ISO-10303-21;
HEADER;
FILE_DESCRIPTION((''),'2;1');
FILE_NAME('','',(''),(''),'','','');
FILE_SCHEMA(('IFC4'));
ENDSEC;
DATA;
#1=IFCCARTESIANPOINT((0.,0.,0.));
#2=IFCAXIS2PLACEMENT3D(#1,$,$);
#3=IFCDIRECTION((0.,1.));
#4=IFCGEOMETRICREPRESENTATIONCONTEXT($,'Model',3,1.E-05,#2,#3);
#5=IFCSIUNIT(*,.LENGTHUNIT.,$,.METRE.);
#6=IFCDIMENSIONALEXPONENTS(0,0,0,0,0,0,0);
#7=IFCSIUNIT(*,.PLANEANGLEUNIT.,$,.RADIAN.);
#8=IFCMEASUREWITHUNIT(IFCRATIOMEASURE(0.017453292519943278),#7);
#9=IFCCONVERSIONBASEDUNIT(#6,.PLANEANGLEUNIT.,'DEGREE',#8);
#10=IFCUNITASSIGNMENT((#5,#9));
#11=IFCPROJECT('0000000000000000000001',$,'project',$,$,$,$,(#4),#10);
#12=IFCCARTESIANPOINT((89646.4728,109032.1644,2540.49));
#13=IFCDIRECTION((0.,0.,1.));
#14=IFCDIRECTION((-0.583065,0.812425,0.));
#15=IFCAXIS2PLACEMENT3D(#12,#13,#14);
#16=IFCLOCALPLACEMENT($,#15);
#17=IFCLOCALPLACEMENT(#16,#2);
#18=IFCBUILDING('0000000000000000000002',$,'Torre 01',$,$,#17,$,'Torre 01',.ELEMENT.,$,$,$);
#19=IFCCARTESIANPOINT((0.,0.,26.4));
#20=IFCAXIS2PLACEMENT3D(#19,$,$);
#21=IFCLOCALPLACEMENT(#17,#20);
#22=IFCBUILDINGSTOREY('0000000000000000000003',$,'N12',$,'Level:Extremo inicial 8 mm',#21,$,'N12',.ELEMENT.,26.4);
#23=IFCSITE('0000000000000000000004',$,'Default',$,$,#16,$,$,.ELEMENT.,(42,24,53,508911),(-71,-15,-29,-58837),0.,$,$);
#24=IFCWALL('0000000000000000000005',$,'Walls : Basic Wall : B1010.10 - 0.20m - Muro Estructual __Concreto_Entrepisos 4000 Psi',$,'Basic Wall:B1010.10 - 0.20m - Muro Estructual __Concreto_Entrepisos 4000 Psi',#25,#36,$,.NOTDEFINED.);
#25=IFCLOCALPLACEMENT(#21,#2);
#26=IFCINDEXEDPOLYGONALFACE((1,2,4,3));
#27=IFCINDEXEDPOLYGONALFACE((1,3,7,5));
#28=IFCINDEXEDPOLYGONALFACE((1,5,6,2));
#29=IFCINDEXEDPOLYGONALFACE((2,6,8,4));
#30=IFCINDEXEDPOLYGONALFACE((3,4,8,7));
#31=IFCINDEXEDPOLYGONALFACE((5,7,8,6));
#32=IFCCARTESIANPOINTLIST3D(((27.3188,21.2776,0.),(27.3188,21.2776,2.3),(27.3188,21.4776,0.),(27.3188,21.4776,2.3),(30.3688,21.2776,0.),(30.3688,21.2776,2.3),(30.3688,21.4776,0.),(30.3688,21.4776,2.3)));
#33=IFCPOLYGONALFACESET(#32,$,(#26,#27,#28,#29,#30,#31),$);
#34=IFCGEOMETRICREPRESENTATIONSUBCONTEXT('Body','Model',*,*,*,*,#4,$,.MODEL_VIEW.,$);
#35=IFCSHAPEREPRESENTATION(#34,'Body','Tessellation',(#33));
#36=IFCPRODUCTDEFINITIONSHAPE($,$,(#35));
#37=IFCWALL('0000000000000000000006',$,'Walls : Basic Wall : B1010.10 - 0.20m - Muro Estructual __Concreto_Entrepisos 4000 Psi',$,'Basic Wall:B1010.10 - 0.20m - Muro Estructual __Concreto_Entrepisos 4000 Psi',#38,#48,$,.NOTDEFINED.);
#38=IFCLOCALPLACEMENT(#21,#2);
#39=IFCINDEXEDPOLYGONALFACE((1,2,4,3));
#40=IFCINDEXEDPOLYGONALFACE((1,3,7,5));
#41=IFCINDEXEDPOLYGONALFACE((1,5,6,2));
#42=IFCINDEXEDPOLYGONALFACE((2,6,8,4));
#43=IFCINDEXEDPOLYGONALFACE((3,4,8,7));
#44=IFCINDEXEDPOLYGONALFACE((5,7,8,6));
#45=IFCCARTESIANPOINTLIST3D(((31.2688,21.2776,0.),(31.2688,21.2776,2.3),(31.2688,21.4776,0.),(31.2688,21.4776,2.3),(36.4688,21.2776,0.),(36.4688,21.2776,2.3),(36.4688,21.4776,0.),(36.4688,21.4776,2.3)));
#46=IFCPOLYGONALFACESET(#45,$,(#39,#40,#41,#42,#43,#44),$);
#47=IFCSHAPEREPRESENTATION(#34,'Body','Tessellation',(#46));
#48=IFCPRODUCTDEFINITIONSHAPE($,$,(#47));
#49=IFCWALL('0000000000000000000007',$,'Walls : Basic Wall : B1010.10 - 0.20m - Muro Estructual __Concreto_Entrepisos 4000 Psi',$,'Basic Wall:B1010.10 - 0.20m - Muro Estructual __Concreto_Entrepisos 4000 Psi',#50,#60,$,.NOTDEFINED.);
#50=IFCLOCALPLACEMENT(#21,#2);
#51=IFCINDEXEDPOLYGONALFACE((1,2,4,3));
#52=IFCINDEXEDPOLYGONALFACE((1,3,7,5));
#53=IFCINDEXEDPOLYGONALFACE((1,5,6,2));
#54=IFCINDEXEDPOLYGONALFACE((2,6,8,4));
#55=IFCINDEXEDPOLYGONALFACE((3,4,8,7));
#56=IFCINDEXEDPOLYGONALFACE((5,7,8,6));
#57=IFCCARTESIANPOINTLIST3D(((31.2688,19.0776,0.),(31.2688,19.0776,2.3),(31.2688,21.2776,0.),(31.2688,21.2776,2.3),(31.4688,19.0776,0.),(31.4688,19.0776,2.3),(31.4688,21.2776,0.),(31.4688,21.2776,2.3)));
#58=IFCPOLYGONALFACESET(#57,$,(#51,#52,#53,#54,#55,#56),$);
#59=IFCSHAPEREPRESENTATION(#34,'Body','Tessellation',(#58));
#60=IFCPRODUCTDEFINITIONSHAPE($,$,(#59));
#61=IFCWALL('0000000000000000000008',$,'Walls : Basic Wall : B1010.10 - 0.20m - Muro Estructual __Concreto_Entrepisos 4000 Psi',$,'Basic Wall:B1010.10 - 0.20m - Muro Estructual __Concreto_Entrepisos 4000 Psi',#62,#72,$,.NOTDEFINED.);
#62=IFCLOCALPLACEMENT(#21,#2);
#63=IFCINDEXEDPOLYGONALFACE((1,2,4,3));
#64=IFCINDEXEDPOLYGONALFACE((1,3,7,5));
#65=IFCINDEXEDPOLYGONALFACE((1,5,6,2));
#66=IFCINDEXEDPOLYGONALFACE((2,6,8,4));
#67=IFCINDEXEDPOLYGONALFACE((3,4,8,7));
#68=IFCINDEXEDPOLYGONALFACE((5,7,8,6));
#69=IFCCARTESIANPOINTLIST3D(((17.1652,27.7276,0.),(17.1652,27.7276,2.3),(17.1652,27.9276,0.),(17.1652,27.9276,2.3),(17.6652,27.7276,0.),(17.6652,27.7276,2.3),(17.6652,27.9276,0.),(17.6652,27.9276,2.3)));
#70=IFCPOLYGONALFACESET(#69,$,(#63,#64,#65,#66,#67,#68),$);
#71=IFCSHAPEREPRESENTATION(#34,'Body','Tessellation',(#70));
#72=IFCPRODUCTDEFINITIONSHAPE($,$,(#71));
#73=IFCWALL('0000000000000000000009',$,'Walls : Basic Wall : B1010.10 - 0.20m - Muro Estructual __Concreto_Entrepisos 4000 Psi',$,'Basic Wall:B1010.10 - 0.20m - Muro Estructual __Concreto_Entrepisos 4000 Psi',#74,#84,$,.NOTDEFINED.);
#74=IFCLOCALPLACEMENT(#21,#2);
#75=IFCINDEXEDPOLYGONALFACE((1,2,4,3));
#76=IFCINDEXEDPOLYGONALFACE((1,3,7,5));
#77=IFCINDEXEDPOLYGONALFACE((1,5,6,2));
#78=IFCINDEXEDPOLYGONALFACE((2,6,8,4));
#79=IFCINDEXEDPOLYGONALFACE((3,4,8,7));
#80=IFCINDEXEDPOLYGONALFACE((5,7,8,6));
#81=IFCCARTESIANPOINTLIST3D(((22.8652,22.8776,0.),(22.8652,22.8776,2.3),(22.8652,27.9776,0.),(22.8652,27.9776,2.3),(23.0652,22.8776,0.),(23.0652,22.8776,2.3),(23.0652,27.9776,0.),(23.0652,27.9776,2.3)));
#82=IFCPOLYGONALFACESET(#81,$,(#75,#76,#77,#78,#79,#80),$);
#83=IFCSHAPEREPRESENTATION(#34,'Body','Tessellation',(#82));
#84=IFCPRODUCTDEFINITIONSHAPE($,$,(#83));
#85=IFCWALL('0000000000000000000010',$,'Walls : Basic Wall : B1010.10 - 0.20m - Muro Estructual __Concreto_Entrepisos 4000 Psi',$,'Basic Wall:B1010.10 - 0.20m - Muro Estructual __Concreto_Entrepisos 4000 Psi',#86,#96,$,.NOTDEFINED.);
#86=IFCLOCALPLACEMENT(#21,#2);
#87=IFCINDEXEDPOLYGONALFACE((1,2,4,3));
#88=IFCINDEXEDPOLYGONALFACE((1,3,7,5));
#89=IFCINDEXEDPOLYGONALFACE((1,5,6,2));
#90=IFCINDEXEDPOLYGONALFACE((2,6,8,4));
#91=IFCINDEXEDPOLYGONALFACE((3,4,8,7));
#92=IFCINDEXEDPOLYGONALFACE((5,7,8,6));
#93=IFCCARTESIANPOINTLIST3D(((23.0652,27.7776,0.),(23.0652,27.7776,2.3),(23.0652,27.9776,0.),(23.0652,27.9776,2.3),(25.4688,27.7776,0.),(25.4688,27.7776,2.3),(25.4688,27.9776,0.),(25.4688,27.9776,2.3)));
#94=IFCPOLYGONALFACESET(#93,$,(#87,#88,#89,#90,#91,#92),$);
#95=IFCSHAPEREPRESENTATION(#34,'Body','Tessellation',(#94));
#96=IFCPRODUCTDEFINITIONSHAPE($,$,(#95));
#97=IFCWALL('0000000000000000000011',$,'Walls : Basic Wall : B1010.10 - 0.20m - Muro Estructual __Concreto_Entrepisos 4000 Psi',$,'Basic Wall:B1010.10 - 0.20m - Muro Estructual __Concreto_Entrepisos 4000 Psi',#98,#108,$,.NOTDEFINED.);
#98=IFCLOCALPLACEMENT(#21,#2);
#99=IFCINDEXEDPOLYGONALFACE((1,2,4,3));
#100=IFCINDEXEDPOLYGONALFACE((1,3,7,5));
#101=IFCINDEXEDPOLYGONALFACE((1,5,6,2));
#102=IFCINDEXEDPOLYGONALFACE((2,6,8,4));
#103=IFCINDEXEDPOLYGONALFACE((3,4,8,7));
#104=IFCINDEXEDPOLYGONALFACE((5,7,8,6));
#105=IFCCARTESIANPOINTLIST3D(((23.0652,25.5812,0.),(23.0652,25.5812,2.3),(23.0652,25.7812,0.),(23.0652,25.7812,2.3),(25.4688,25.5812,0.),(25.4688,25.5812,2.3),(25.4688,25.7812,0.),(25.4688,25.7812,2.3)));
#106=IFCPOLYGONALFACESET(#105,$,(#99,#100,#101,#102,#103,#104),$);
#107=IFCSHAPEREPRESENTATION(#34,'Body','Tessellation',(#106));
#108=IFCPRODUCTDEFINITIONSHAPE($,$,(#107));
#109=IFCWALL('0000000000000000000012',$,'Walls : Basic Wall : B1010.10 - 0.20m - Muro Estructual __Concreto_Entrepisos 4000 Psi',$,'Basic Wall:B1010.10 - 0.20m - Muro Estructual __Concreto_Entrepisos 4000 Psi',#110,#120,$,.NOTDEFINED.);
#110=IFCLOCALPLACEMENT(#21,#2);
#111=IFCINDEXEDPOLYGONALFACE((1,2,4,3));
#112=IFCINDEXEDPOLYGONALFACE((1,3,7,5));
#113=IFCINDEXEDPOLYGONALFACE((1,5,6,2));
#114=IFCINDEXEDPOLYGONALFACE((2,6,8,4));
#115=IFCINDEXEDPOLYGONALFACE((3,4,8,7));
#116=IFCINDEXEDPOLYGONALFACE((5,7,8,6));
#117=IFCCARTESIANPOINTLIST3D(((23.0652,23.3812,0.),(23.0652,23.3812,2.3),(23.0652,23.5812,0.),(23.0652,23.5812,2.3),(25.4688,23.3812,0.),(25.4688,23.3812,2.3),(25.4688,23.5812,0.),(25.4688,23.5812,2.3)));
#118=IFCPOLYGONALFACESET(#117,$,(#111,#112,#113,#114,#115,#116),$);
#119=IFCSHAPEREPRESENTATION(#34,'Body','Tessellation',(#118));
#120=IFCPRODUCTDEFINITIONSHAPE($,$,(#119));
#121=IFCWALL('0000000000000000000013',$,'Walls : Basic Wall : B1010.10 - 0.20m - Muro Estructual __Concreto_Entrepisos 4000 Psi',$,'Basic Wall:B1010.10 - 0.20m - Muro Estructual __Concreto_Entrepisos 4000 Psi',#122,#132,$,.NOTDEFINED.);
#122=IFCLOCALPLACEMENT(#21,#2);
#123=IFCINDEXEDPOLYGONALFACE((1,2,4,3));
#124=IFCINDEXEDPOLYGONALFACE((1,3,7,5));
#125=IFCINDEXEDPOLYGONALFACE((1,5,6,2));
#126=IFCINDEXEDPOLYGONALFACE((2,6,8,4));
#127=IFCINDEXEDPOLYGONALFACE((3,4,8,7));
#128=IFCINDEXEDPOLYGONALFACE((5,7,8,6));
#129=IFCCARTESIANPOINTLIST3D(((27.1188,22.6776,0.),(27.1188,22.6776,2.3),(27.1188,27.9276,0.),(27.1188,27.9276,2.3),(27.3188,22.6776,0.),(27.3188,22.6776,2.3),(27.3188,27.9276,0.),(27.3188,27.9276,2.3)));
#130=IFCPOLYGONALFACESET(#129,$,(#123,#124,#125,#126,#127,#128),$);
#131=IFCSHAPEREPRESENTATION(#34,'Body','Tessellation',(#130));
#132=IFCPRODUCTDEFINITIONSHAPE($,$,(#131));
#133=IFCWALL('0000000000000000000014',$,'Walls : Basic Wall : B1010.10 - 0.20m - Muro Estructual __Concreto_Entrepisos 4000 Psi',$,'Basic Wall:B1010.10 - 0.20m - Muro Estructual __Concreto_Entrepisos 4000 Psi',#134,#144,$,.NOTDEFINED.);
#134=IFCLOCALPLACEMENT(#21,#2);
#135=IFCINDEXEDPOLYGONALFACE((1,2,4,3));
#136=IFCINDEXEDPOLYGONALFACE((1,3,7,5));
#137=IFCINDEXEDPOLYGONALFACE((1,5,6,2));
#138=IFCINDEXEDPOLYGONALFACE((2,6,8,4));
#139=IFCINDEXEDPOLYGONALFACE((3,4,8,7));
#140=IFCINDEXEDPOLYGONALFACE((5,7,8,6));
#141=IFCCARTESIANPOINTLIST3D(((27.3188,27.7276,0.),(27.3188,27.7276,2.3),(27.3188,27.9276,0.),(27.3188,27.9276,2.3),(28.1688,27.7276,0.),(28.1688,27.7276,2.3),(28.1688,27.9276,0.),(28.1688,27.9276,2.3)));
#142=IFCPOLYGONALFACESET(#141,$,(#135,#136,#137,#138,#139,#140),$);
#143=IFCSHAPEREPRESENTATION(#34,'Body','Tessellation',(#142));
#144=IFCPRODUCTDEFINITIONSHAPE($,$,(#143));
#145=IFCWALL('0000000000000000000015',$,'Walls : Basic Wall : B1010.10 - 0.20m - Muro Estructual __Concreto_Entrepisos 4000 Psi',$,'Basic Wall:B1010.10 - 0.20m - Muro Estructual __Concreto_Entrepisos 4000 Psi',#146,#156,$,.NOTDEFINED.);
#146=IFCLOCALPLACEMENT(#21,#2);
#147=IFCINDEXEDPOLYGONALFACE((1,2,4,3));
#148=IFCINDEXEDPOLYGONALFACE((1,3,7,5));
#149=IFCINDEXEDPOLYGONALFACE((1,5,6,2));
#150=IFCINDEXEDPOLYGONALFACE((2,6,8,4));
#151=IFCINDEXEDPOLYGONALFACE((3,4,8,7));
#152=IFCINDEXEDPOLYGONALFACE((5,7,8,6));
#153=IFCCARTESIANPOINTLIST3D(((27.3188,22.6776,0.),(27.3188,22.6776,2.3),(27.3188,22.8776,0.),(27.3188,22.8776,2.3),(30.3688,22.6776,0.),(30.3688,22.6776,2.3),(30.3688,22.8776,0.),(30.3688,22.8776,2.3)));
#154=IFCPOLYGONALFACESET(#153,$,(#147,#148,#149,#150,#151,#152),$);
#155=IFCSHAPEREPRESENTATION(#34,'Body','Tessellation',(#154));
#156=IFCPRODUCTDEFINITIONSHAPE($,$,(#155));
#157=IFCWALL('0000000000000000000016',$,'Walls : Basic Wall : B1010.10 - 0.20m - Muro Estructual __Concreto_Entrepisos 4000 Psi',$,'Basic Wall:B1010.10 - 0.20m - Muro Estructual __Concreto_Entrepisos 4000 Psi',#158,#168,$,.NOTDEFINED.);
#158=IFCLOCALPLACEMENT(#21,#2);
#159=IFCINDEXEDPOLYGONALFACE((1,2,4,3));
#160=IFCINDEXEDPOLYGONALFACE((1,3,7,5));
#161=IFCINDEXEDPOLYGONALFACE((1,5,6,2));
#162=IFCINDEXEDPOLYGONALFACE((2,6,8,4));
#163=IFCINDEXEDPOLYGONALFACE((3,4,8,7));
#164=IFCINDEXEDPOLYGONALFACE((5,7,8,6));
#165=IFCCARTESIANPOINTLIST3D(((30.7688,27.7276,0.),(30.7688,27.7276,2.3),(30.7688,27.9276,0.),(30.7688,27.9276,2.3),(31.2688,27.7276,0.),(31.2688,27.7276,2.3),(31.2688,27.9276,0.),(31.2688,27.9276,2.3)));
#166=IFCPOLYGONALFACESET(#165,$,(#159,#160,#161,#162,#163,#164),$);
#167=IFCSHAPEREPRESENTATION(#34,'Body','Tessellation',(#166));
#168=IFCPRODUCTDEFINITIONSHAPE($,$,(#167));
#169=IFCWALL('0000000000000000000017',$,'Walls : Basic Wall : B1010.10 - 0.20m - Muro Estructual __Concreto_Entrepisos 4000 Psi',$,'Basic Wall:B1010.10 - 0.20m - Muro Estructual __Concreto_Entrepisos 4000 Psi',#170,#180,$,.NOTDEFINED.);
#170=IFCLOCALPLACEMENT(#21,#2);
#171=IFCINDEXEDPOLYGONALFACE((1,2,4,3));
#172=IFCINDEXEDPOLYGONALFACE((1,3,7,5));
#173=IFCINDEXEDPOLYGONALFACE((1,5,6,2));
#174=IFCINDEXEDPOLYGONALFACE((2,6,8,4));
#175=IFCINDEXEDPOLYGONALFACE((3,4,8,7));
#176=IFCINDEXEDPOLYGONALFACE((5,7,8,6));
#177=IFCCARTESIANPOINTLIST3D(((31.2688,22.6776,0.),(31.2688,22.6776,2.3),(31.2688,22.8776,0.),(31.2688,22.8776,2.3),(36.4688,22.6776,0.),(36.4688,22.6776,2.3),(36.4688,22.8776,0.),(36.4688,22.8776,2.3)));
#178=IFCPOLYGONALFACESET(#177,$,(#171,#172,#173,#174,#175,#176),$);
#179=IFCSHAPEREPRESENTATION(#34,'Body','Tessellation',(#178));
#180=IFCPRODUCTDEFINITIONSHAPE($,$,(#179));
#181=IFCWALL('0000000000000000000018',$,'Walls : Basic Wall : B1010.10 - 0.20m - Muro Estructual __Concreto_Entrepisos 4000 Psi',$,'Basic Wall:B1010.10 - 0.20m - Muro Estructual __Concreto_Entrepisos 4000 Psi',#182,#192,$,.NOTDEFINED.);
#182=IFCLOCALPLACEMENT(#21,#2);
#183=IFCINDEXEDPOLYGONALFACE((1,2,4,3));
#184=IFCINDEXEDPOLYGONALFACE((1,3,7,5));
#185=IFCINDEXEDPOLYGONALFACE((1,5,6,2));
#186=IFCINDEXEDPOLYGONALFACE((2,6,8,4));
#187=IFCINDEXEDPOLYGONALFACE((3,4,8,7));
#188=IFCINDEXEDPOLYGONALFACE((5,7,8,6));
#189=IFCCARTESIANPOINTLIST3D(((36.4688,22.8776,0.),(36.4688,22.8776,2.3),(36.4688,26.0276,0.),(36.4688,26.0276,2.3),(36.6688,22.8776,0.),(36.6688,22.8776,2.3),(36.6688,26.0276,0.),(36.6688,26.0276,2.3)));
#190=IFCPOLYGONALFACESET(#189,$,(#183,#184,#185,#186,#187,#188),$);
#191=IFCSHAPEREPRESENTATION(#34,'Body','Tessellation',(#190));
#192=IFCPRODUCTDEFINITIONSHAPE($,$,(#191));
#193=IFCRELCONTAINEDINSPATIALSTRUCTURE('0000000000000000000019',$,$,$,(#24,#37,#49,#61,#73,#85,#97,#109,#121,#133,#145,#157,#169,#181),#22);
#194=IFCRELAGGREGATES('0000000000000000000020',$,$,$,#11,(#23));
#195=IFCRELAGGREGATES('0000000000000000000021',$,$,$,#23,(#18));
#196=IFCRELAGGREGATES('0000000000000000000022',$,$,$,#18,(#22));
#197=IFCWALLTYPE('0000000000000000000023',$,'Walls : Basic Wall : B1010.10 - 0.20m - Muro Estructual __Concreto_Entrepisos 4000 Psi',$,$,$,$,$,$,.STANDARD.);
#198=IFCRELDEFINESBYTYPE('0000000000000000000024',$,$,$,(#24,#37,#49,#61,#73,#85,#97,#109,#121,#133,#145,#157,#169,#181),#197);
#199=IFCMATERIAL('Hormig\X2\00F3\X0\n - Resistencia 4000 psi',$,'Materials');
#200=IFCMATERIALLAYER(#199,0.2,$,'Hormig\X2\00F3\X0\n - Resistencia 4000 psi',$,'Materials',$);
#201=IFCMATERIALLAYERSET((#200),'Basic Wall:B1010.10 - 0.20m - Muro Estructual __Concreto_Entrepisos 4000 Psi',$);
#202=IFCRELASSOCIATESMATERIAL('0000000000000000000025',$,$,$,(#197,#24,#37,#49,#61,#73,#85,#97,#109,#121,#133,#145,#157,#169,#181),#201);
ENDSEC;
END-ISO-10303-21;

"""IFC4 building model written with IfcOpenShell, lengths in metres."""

from ifc_helpers import new_model, entity, si_unit, converted_unit, direction, frame, frame_2d, origin, place, context, subcontext, project, spatial, rectangle, extrude, material, layer, layer_set, layer_usage, type_object, element, save


model = new_model("IFC4")

# Units and contexts
model_context = context("Model", 3, precision=1e-05, world=origin(), true_north=direction((0.0, 1.0)))
body_context = subcontext(model_context, "Body", "Model", "MODEL_VIEW")
ifc_project = project(units=[si_unit("LENGTHUNIT", "METRE"), converted_unit("PLANEANGLEUNIT", "DEGREE", entity("IfcRatioMeasure", 0.017453292519943278), si_unit("PLANEANGLEUNIT", "RADIAN"), dimensions=[0, 0, 0, 0, 0, 0, 0])], contexts=[model_context])

# Site, building, storey
site_placement = place(None, frame((89646.4728, 109032.1644, 2540.49), z_axis=(0.0, 0.0, 1.0), x_axis=(-0.583065, 0.812425, 0.0)))
site = spatial("IfcSite", under=ifc_project, at=site_placement, Name="Default", CompositionType="ELEMENT", RefLatitude=(42, 24, 53, 508911), RefLongitude=(-71, -15, -29, -58837), RefElevation=0.0)
building_placement = place(site_placement, origin())
building = spatial("IfcBuilding", under=site, at=building_placement, Name="Torre 01", LongName="Torre 01", CompositionType="ELEMENT")
storey_placement = place(building_placement, frame((0.0, 0.0, 26.4)))
storey = spatial("IfcBuildingStorey", under=building, at=storey_placement, Name="N12", ObjectType="Level:Extremo inicial 8 mm", LongName="N12", CompositionType="ELEMENT", Elevation=26.4)

# Walls
ifc_material = material(Name="Hormigón - Resistencia 4000 psi", Category="Materials")
ifc_layer_1 = layer(ifc_material, 0.2, Name="Hormigón - Resistencia 4000 psi", Category="Materials")
ifc_layer_set_1 = layer_set([ifc_layer_1], Name="Basic Wall:B1010.10 - 0.20m - Muro Estructual __Concreto_Entrepisos 4000 Psi")
ifc_layer_usage_1 = layer_usage(ifc_layer_set_1, "AXIS2", "NEGATIVE", 0.1)
wall_type_1 = type_object("IfcWallType", Name="Walls : Basic Wall : B1010.10 - 0.20m - Muro Estructual __Concreto_Entrepisos 4000 Psi", PredefinedType="STANDARD", material=ifc_layer_set_1)
wall_1_placement = place(storey_placement, frame((27.3188, 21.3776, 0.0)))
element("IfcWall", 1, at=wall_1_placement, inside=storey, type_object=wall_type_1, material=ifc_layer_usage_1, Name="Walls : Basic Wall : B1010.10 - 0.20m - Muro Estructual __Concreto_Entrepisos 4000 Psi", ObjectType="Basic Wall:B1010.10 - 0.20m - Muro Estructual __Concreto_Entrepisos 4000 Psi", PredefinedType="NOTDEFINED", context=body_context, shape_type="SweptSolid", body=[
    extrude(rectangle(XDim=3.05, YDim=0.2, at=frame_2d((1.525, 0.0), x_axis=(-1.0, 0.0))), origin(), (0.0, 0.0, 1.0), 2.3),
])
ifc_layer_usage_2 = layer_usage(ifc_layer_set_1, "AXIS2", "NEGATIVE", 0.1)
wall_2_placement = place(storey_placement, frame((31.2688, 21.3776, 0.0)))
element("IfcWall", 2, at=wall_2_placement, inside=storey, type_object=wall_type_1, material=ifc_layer_usage_2, Name="Walls : Basic Wall : B1010.10 - 0.20m - Muro Estructual __Concreto_Entrepisos 4000 Psi", ObjectType="Basic Wall:B1010.10 - 0.20m - Muro Estructual __Concreto_Entrepisos 4000 Psi", PredefinedType="NOTDEFINED", context=body_context, shape_type="SweptSolid", body=[
    extrude(rectangle(XDim=5.2, YDim=0.2, at=frame_2d((2.6, 0.0), x_axis=(-1.0, 0.0))), origin(), (0.0, 0.0, 1.0), 2.3),
])
ifc_layer_usage_3 = layer_usage(ifc_layer_set_1, "AXIS2", "NEGATIVE", 0.1)
wall_3_placement = place(storey_placement, frame((31.3688, 21.2776, 0.0), z_axis=(0.0, 0.0, 1.0), x_axis=(0.0, -1.0, 0.0)))
element("IfcWall", 3, at=wall_3_placement, inside=storey, type_object=wall_type_1, material=ifc_layer_usage_3, Name="Walls : Basic Wall : B1010.10 - 0.20m - Muro Estructual __Concreto_Entrepisos 4000 Psi", ObjectType="Basic Wall:B1010.10 - 0.20m - Muro Estructual __Concreto_Entrepisos 4000 Psi", PredefinedType="NOTDEFINED", context=body_context, shape_type="SweptSolid", body=[
    extrude(rectangle(XDim=2.2, YDim=0.2, at=frame_2d((1.1, 0.0), x_axis=(-1.0, 0.0))), origin(), (0.0, 0.0, 1.0), 2.3),
])
ifc_layer_usage_4 = layer_usage(ifc_layer_set_1, "AXIS2", "POSITIVE", -0.1)
wall_4_placement = place(storey_placement, frame((17.6652, 27.8276, 0.0), z_axis=(0.0, 0.0, 1.0), x_axis=(-1.0, 0.0, 0.0)))
element("IfcWall", 4, at=wall_4_placement, inside=storey, type_object=wall_type_1, material=ifc_layer_usage_4, Name="Walls : Basic Wall : B1010.10 - 0.20m - Muro Estructual __Concreto_Entrepisos 4000 Psi", ObjectType="Basic Wall:B1010.10 - 0.20m - Muro Estructual __Concreto_Entrepisos 4000 Psi", PredefinedType="NOTDEFINED", context=body_context, shape_type="SweptSolid", body=[
    extrude(rectangle(XDim=0.5, YDim=0.2, at=frame_2d((0.25, 0.0), x_axis=(-1.0, 0.0))), origin(), (0.0, 0.0, 1.0), 2.3),
])
ifc_layer_usage_5 = layer_usage(ifc_layer_set_1, "AXIS2", "NEGATIVE", 0.1)
wall_5_placement = place(storey_placement, frame((22.9652, 22.8776, 0.0), z_axis=(0.0, 0.0, 1.0), x_axis=(0.0, 1.0, 0.0)))
element("IfcWall", 5, at=wall_5_placement, inside=storey, type_object=wall_type_1, material=ifc_layer_usage_5, Name="Walls : Basic Wall : B1010.10 - 0.20m - Muro Estructual __Concreto_Entrepisos 4000 Psi", ObjectType="Basic Wall:B1010.10 - 0.20m - Muro Estructual __Concreto_Entrepisos 4000 Psi", PredefinedType="NOTDEFINED", context=body_context, shape_type="SweptSolid", body=[
    extrude(rectangle(XDim=5.1, YDim=0.2, at=frame_2d((2.55, 0.0), x_axis=(-1.0, 0.0))), origin(), (0.0, 0.0, 1.0), 2.3),
])
ifc_layer_usage_6 = layer_usage(ifc_layer_set_1, "AXIS2", "NEGATIVE", 0.1)
wall_6_placement = place(storey_placement, frame((23.0652, 27.8776, 0.0)))
element("IfcWall", 6, at=wall_6_placement, inside=storey, type_object=wall_type_1, material=ifc_layer_usage_6, Name="Walls : Basic Wall : B1010.10 - 0.20m - Muro Estructual __Concreto_Entrepisos 4000 Psi", ObjectType="Basic Wall:B1010.10 - 0.20m - Muro Estructual __Concreto_Entrepisos 4000 Psi", PredefinedType="NOTDEFINED", context=body_context, shape_type="SweptSolid", body=[
    extrude(rectangle(XDim=2.4037, YDim=0.2, at=frame_2d((1.2018, 0.0), x_axis=(-1.0, 0.0))), origin(), (0.0, 0.0, 1.0), 2.3),
])
ifc_layer_usage_7 = layer_usage(ifc_layer_set_1, "AXIS2", "NEGATIVE", 0.1)
wall_7_placement = place(storey_placement, frame((23.0652, 25.6812, 0.0)))
element("IfcWall", 7, at=wall_7_placement, inside=storey, type_object=wall_type_1, material=ifc_layer_usage_7, Name="Walls : Basic Wall : B1010.10 - 0.20m - Muro Estructual __Concreto_Entrepisos 4000 Psi", ObjectType="Basic Wall:B1010.10 - 0.20m - Muro Estructual __Concreto_Entrepisos 4000 Psi", PredefinedType="NOTDEFINED", context=body_context, shape_type="SweptSolid", body=[
    extrude(rectangle(XDim=2.4037, YDim=0.2, at=frame_2d((1.2018, 0.0), x_axis=(-1.0, 0.0))), origin(), (0.0, 0.0, 1.0), 2.3),
])
ifc_layer_usage_8 = layer_usage(ifc_layer_set_1, "AXIS2", "NEGATIVE", 0.1)
wall_8_placement = place(storey_placement, frame((23.0652, 23.4812, 0.0)))
element("IfcWall", 8, at=wall_8_placement, inside=storey, type_object=wall_type_1, material=ifc_layer_usage_8, Name="Walls : Basic Wall : B1010.10 - 0.20m - Muro Estructual __Concreto_Entrepisos 4000 Psi", ObjectType="Basic Wall:B1010.10 - 0.20m - Muro Estructual __Concreto_Entrepisos 4000 Psi", PredefinedType="NOTDEFINED", context=body_context, shape_type="SweptSolid", body=[
    extrude(rectangle(XDim=2.4037, YDim=0.2, at=frame_2d((1.2018, 0.0), x_axis=(-1.0, 0.0))), origin(), (0.0, 0.0, 1.0), 2.3),
])
ifc_layer_usage_9 = layer_usage(ifc_layer_set_1, "AXIS2", "POSITIVE", -0.1)
wall_9_placement = place(storey_placement, frame((27.2188, 27.9276, 0.0), z_axis=(0.0, 0.0, 1.0), x_axis=(0.0, -1.0, 0.0)))
element("IfcWall", 9, at=wall_9_placement, inside=storey, type_object=wall_type_1, material=ifc_layer_usage_9, Name="Walls : Basic Wall : B1010.10 - 0.20m - Muro Estructual __Concreto_Entrepisos 4000 Psi", ObjectType="Basic Wall:B1010.10 - 0.20m - Muro Estructual __Concreto_Entrepisos 4000 Psi", PredefinedType="NOTDEFINED", context=body_context, shape_type="SweptSolid", body=[
    extrude(rectangle(XDim=5.25, YDim=0.2, at=frame_2d((2.625, 0.0), x_axis=(-1.0, 0.0))), origin(), (0.0, 0.0, 1.0), 2.3),
])
ifc_layer_usage_10 = layer_usage(ifc_layer_set_1, "AXIS2", "POSITIVE", -0.1)
wall_10_placement = place(storey_placement, frame((27.3188, 27.8276, 0.0)))
element("IfcWall", 10, at=wall_10_placement, inside=storey, type_object=wall_type_1, material=ifc_layer_usage_10, Name="Walls : Basic Wall : B1010.10 - 0.20m - Muro Estructual __Concreto_Entrepisos 4000 Psi", ObjectType="Basic Wall:B1010.10 - 0.20m - Muro Estructual __Concreto_Entrepisos 4000 Psi", PredefinedType="NOTDEFINED", context=body_context, shape_type="SweptSolid", body=[
    extrude(rectangle(XDim=0.85, YDim=0.2, at=frame_2d((0.425, 0.0), x_axis=(-1.0, 0.0))), origin(), (0.0, 0.0, 1.0), 2.3),
])
ifc_layer_usage_11 = layer_usage(ifc_layer_set_1, "AXIS2", "POSITIVE", -0.1)
wall_11_placement = place(storey_placement, frame((27.3188, 22.7776, 0.0)))
element("IfcWall", 11, at=wall_11_placement, inside=storey, type_object=wall_type_1, material=ifc_layer_usage_11, Name="Walls : Basic Wall : B1010.10 - 0.20m - Muro Estructual __Concreto_Entrepisos 4000 Psi", ObjectType="Basic Wall:B1010.10 - 0.20m - Muro Estructual __Concreto_Entrepisos 4000 Psi", PredefinedType="NOTDEFINED", context=body_context, shape_type="SweptSolid", body=[
    extrude(rectangle(XDim=3.05, YDim=0.2, at=frame_2d((1.525, 0.0), x_axis=(-1.0, 0.0))), origin(), (0.0, 0.0, 1.0), 2.3),
])
ifc_layer_usage_12 = layer_usage(ifc_layer_set_1, "AXIS2", "POSITIVE", -0.1)
wall_12_placement = place(storey_placement, frame((30.7688, 27.8276, 0.0)))
element("IfcWall", 12, at=wall_12_placement, inside=storey, type_object=wall_type_1, material=ifc_layer_usage_12, Name="Walls : Basic Wall : B1010.10 - 0.20m - Muro Estructual __Concreto_Entrepisos 4000 Psi", ObjectType="Basic Wall:B1010.10 - 0.20m - Muro Estructual __Concreto_Entrepisos 4000 Psi", PredefinedType="NOTDEFINED", context=body_context, shape_type="SweptSolid", body=[
    extrude(rectangle(XDim=0.5, YDim=0.2, at=frame_2d((0.25, 0.0), x_axis=(-1.0, 0.0))), origin(), (0.0, 0.0, 1.0), 2.3),
])
ifc_layer_usage_13 = layer_usage(ifc_layer_set_1, "AXIS2", "POSITIVE", -0.1)
wall_13_placement = place(storey_placement, frame((31.2688, 22.7776, 0.0)))
element("IfcWall", 13, at=wall_13_placement, inside=storey, type_object=wall_type_1, material=ifc_layer_usage_13, Name="Walls : Basic Wall : B1010.10 - 0.20m - Muro Estructual __Concreto_Entrepisos 4000 Psi", ObjectType="Basic Wall:B1010.10 - 0.20m - Muro Estructual __Concreto_Entrepisos 4000 Psi", PredefinedType="NOTDEFINED", context=body_context, shape_type="SweptSolid", body=[
    extrude(rectangle(XDim=5.2, YDim=0.2, at=frame_2d((2.6, 0.0), x_axis=(-1.0, 0.0))), origin(), (0.0, 0.0, 1.0), 2.3),
])
ifc_layer_usage_14 = layer_usage(ifc_layer_set_1, "AXIS2", "POSITIVE", -0.1)
wall_14_placement = place(storey_placement, frame((36.5688, 26.0276, 0.0), z_axis=(0.0, 0.0, 1.0), x_axis=(0.0, -1.0, 0.0)))
element("IfcWall", 14, at=wall_14_placement, inside=storey, type_object=wall_type_1, material=ifc_layer_usage_14, Name="Walls : Basic Wall : B1010.10 - 0.20m - Muro Estructual __Concreto_Entrepisos 4000 Psi", ObjectType="Basic Wall:B1010.10 - 0.20m - Muro Estructual __Concreto_Entrepisos 4000 Psi", PredefinedType="NOTDEFINED", context=body_context, shape_type="SweptSolid", body=[
    extrude(rectangle(XDim=3.15, YDim=0.2, at=frame_2d((1.575, 0.0), x_axis=(-1.0, 0.0))), origin(), (0.0, 0.0, 1.0), 2.3),
])

save(model, "model.ifc")
